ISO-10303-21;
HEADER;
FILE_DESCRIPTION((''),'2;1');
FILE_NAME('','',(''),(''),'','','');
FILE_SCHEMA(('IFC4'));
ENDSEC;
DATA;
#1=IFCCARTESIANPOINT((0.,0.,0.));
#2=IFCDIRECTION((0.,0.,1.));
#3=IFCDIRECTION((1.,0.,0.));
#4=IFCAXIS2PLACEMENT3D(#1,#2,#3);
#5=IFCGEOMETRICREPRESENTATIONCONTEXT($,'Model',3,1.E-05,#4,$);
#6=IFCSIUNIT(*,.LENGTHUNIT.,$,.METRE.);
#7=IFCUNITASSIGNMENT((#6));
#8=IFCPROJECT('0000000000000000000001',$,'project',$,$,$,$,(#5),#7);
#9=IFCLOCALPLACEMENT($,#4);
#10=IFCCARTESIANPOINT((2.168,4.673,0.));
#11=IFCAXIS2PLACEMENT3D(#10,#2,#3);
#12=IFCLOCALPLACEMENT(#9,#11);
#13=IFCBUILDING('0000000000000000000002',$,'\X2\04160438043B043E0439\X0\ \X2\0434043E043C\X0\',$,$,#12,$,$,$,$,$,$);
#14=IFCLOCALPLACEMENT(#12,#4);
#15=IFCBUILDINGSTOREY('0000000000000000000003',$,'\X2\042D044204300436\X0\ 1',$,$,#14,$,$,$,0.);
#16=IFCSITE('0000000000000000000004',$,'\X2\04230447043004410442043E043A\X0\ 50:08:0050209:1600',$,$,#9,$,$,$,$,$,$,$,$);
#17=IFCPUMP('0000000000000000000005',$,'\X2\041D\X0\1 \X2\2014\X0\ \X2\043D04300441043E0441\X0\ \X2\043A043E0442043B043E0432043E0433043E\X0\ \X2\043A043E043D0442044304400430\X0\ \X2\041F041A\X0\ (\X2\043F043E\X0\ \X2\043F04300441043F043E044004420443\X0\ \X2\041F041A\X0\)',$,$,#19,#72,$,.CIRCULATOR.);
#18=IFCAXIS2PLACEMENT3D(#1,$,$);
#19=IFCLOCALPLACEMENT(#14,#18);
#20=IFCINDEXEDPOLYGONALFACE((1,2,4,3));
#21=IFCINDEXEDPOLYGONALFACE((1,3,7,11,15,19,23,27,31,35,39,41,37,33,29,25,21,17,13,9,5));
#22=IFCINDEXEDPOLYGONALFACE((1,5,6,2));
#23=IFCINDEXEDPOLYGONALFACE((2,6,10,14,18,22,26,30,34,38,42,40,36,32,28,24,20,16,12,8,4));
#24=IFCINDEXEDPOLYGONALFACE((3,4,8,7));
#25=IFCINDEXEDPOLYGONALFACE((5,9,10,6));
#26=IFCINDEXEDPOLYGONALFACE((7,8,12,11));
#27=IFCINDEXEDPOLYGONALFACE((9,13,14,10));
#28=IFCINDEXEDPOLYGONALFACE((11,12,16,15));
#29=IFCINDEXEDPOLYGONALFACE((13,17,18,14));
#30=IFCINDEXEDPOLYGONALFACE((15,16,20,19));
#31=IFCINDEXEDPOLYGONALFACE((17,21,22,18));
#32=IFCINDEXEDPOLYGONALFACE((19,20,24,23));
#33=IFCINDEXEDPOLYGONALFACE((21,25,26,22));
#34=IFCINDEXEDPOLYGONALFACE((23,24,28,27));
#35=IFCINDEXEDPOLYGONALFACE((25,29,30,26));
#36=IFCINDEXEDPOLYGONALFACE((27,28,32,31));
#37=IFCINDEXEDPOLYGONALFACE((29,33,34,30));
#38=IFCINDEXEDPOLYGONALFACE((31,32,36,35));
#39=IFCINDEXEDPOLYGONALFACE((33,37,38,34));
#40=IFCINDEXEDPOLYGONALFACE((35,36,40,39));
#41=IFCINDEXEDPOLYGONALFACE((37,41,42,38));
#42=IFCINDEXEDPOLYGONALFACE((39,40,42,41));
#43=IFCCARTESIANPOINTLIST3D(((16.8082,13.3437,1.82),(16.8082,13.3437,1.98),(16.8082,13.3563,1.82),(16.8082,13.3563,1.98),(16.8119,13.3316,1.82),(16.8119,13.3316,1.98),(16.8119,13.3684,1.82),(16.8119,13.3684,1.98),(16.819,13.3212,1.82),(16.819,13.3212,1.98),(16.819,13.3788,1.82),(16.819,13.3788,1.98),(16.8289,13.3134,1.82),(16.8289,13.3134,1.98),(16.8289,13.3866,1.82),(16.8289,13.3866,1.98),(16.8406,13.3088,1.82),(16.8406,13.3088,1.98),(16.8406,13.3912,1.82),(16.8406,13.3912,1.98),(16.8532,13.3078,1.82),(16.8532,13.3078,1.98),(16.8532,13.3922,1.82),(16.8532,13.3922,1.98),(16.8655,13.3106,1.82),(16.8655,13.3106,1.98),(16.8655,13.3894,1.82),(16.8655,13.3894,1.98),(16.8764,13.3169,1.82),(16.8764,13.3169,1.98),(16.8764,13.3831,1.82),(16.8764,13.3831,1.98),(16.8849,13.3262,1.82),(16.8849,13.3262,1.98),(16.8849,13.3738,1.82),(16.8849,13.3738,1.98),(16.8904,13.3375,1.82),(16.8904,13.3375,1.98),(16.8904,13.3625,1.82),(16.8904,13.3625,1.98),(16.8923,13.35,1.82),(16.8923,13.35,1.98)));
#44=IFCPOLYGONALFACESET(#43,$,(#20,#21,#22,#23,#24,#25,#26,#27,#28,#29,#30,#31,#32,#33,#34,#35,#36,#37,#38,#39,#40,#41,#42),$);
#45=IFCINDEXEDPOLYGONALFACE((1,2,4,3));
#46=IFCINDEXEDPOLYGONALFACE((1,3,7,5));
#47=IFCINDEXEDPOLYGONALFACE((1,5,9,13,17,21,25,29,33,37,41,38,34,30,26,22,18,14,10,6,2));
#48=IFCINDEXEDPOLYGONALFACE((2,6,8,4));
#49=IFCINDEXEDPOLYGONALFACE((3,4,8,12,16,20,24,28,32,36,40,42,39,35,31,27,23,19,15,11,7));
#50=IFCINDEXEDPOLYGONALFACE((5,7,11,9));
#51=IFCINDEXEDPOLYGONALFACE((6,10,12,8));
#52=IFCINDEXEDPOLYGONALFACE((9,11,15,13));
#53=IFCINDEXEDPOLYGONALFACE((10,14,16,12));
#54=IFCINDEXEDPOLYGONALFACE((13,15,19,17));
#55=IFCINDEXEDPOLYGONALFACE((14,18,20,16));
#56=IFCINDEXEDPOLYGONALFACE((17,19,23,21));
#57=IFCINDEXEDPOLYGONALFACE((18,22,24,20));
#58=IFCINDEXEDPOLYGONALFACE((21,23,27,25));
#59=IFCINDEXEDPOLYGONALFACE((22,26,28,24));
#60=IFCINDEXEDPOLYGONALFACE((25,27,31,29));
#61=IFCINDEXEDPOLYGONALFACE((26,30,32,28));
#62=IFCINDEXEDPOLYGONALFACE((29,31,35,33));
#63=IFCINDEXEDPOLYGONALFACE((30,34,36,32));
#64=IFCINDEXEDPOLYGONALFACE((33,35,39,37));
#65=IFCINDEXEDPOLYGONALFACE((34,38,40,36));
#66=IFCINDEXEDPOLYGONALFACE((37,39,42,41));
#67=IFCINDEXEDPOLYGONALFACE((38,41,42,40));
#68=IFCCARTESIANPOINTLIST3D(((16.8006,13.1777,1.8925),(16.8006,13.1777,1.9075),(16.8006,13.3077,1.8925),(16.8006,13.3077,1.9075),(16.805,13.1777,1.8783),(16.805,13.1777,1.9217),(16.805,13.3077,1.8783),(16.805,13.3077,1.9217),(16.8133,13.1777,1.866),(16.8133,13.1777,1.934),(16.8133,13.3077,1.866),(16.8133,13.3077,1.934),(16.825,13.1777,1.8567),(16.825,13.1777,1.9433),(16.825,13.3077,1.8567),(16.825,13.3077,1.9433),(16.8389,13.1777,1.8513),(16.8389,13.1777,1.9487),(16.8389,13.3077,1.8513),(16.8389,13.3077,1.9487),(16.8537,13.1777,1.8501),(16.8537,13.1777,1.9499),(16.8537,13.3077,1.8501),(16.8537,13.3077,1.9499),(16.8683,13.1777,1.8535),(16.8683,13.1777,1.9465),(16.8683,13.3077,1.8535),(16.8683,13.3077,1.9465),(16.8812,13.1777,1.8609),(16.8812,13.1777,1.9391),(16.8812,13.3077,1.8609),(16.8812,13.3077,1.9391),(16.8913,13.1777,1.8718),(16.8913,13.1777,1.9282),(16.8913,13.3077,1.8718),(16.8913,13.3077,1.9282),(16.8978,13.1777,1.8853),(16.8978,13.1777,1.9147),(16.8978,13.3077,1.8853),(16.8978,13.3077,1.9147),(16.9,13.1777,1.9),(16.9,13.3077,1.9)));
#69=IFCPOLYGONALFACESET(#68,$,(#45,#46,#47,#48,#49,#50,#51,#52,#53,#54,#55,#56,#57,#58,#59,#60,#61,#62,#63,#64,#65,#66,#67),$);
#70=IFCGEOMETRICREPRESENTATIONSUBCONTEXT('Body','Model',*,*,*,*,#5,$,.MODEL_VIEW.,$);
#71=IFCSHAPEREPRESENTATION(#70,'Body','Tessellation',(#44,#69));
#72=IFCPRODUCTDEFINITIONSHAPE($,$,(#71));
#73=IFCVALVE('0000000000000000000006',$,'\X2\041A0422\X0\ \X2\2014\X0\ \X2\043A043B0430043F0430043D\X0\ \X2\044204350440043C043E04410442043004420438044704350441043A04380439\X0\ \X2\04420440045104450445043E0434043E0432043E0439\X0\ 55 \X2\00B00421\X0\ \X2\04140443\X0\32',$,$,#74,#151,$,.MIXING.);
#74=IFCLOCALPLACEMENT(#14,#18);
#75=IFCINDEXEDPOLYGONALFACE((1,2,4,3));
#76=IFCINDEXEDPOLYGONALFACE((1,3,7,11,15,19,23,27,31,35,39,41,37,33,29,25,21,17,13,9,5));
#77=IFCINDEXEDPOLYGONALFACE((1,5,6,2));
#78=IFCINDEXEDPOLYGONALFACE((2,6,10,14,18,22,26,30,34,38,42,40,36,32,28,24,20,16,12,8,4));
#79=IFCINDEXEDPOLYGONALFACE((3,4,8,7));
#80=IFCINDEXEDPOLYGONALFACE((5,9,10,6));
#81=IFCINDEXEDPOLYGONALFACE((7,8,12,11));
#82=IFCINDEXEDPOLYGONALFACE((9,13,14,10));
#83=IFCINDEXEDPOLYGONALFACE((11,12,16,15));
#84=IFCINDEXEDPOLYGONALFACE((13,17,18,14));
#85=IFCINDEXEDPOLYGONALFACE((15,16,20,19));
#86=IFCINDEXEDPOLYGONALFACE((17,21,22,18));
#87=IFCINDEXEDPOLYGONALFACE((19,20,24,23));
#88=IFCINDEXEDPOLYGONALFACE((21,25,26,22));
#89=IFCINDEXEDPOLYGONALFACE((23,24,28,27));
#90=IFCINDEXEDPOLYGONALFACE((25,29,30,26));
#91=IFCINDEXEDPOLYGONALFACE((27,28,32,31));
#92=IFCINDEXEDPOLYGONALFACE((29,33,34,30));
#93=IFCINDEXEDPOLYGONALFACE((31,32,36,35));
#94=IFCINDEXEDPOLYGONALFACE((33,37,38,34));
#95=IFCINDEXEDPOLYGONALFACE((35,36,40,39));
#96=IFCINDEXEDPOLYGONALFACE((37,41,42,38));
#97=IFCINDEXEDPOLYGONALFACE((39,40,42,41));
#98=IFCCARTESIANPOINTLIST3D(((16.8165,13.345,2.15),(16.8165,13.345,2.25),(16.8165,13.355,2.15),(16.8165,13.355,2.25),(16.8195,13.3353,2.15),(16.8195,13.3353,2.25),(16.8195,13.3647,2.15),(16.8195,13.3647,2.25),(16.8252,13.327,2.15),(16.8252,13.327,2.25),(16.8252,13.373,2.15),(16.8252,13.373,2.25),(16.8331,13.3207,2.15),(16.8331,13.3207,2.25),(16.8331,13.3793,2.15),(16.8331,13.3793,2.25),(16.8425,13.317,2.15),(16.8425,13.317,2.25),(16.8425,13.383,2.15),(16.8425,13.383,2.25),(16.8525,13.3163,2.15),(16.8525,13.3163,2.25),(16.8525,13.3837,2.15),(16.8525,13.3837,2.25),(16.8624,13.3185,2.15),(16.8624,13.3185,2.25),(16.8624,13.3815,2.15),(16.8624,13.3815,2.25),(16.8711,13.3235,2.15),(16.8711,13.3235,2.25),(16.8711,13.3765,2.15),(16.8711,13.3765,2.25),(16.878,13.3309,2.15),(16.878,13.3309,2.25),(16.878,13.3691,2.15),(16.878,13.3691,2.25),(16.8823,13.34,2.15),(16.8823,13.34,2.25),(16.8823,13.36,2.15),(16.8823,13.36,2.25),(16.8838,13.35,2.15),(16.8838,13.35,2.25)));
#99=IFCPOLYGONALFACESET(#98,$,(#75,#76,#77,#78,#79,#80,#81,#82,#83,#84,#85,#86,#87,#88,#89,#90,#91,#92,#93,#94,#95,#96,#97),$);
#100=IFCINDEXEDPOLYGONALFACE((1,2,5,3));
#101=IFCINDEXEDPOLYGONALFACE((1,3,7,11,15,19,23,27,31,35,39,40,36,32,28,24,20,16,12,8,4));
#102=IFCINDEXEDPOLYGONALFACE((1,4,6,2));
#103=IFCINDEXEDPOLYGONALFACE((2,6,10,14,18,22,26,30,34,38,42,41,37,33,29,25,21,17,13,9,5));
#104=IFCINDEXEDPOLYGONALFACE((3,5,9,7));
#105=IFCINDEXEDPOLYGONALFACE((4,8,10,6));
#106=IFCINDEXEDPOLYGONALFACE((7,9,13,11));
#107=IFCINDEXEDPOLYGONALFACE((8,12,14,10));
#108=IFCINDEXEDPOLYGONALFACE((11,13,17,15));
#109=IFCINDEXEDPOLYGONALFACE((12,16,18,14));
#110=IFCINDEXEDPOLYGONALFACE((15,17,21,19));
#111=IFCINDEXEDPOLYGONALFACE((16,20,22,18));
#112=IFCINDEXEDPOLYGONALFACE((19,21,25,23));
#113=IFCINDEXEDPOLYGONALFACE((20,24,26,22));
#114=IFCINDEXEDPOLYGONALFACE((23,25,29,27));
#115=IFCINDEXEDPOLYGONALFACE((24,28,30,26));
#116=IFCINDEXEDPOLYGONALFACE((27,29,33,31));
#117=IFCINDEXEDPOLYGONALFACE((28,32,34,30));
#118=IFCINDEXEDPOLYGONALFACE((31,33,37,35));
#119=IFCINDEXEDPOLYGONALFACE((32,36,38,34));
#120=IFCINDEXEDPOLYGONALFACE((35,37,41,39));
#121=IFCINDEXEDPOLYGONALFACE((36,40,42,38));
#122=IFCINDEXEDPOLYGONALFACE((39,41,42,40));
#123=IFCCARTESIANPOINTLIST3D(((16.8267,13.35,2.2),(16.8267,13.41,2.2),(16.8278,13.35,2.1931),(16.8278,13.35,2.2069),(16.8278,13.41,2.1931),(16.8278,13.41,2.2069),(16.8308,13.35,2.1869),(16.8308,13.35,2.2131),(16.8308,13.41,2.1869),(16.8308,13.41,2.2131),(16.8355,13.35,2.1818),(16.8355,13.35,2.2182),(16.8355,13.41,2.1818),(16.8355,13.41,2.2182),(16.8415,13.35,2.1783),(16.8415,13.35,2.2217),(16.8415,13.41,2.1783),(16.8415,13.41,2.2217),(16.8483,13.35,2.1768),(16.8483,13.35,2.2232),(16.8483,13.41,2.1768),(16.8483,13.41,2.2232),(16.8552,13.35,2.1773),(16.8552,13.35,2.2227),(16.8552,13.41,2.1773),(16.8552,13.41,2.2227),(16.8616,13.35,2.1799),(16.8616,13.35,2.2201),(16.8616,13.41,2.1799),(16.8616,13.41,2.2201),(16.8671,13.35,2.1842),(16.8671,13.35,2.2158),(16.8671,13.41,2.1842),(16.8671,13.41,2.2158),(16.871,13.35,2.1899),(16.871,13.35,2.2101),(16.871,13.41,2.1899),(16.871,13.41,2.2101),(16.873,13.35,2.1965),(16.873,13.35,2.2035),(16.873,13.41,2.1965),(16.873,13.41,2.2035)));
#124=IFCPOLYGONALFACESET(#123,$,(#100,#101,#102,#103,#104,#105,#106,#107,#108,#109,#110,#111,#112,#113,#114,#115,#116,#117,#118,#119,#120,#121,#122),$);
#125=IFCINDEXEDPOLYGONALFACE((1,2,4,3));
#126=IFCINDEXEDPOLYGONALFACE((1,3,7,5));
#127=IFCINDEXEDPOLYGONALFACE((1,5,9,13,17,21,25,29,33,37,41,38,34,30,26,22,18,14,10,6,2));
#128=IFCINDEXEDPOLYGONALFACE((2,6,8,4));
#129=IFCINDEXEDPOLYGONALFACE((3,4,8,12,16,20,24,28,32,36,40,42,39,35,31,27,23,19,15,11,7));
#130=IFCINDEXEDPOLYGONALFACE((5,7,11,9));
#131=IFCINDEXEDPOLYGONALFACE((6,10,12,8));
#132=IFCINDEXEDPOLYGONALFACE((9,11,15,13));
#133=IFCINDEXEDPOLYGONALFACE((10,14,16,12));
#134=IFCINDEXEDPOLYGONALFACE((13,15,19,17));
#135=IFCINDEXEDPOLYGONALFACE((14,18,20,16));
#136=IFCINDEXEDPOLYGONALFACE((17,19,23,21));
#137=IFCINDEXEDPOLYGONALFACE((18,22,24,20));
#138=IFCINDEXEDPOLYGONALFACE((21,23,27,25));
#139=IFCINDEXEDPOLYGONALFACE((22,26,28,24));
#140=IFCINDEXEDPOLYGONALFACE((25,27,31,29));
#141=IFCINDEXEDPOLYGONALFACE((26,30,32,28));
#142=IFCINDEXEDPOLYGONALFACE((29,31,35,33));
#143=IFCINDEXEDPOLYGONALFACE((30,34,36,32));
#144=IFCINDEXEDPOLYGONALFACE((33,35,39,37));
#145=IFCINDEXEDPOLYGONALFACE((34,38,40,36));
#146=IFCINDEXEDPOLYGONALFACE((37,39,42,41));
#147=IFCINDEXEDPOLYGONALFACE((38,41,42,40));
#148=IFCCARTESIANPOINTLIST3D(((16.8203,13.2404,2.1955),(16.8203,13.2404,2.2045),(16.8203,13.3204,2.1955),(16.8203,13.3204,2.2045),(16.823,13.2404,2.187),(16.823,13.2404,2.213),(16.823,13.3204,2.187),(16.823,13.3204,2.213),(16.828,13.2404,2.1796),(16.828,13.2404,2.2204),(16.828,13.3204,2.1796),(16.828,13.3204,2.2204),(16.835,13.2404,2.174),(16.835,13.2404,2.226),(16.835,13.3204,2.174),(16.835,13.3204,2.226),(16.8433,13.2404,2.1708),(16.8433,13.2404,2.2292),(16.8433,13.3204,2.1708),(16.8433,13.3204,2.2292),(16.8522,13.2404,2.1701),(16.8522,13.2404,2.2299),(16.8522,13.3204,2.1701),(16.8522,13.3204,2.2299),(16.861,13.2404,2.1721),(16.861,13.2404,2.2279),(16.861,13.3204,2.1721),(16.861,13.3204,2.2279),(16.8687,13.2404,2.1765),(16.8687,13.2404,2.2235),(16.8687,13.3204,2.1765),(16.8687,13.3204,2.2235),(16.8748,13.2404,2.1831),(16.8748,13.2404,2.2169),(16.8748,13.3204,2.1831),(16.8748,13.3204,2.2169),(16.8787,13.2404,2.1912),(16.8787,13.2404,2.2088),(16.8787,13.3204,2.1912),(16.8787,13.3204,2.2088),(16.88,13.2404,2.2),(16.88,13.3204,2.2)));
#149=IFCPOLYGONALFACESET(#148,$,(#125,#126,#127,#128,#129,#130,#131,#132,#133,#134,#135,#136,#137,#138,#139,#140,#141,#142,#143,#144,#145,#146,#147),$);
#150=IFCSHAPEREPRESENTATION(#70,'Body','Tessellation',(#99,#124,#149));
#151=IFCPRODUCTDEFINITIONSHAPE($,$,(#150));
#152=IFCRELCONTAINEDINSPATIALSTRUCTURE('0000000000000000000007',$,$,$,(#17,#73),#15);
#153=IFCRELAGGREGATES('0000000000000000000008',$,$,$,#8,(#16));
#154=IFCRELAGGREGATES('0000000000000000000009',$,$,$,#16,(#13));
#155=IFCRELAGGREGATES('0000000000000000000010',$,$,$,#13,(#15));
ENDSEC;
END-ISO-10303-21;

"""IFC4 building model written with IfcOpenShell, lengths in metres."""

from ifc_helpers import new_model, si_unit, frame, origin_with_axes, origin_2d, place, context, subcontext, project, spatial, circle, extrude, element, save


model = new_model("IFC4")

# Units and contexts
model_context = context("Model", 3, precision=1e-05, world=origin_with_axes())
body_context = subcontext(model_context, "Body", "Model", "MODEL_VIEW")
ifc_project = project(units=[si_unit("LENGTHUNIT", "METRE")], contexts=[model_context])

# Site, building, storey
site_placement = place(None, origin_with_axes())
site = spatial("IfcSite", under=ifc_project, at=site_placement, Name="Участок 50:08:0050209:1600")
building_placement = place(site_placement, frame((2.168, 4.673, 0.0), z_axis=(0.0, 0.0, 1.0), x_axis=(1.0, 0.0, 0.0)))
building = spatial("IfcBuilding", under=site, at=building_placement, Name="Жилой дом")
storey_placement = place(building_placement, origin_with_axes())
storey = spatial("IfcBuildingStorey", under=building, at=storey_placement, Name="Этаж 1", Elevation=0.0)

# Pump
pump_placement = place(storey_placement, origin_with_axes())
element("IfcPump", 1, at=pump_placement, inside=storey, Name="Н1 — насос котлового контура ПК (по паспорту ПК)", PredefinedType="CIRCULATOR", context=body_context, shape_type="SweptSolid", body=[
    extrude(circle(Radius=0.0423, at=origin_2d()), frame((16.85, 13.35, 1.82), z_axis=(0.0, 0.0, 1.0), x_axis=(1.0, 0.0, 0.0)), (0.0, 0.0, 1.0), 0.16),
    extrude(circle(Radius=0.05, at=origin_2d()), frame((16.85, 13.3077, 1.9), z_axis=(0.0, -1.0, 0.0), x_axis=(1.0, 0.0, 0.0)), (0.0, 0.0, 1.0), 0.13),
])

# Valve
valve_1_placement = place(storey_placement, origin_with_axes())
element("IfcValve", 2, at=valve_1_placement, inside=storey, Name="КТ — клапан термостатический трёхходовой 55 °С Ду32", PredefinedType="MIXING", context=body_context, shape_type="SweptSolid", body=[
    extrude(circle(Radius=0.0338, at=origin_2d()), frame((16.85, 13.35, 2.15), z_axis=(0.0, 0.0, 1.0), x_axis=(1.0, 0.0, 0.0)), (0.0, 0.0, 1.0), 0.1),
    extrude(circle(Radius=0.0233, at=origin_2d()), frame((16.85, 13.35, 2.2), z_axis=(0.0, 1.0, 0.0), x_axis=(-1.0, 0.0, 0.0)), (0.0, 0.0, 1.0), 0.06),
    extrude(circle(Radius=0.03, at=origin_2d()), frame((16.85, 13.3204, 2.2), z_axis=(0.0, -1.0, 0.0), x_axis=(1.0, 0.0, 0.0)), (0.0, 0.0, 1.0), 0.08),
])

save(model, "model.ifc")
